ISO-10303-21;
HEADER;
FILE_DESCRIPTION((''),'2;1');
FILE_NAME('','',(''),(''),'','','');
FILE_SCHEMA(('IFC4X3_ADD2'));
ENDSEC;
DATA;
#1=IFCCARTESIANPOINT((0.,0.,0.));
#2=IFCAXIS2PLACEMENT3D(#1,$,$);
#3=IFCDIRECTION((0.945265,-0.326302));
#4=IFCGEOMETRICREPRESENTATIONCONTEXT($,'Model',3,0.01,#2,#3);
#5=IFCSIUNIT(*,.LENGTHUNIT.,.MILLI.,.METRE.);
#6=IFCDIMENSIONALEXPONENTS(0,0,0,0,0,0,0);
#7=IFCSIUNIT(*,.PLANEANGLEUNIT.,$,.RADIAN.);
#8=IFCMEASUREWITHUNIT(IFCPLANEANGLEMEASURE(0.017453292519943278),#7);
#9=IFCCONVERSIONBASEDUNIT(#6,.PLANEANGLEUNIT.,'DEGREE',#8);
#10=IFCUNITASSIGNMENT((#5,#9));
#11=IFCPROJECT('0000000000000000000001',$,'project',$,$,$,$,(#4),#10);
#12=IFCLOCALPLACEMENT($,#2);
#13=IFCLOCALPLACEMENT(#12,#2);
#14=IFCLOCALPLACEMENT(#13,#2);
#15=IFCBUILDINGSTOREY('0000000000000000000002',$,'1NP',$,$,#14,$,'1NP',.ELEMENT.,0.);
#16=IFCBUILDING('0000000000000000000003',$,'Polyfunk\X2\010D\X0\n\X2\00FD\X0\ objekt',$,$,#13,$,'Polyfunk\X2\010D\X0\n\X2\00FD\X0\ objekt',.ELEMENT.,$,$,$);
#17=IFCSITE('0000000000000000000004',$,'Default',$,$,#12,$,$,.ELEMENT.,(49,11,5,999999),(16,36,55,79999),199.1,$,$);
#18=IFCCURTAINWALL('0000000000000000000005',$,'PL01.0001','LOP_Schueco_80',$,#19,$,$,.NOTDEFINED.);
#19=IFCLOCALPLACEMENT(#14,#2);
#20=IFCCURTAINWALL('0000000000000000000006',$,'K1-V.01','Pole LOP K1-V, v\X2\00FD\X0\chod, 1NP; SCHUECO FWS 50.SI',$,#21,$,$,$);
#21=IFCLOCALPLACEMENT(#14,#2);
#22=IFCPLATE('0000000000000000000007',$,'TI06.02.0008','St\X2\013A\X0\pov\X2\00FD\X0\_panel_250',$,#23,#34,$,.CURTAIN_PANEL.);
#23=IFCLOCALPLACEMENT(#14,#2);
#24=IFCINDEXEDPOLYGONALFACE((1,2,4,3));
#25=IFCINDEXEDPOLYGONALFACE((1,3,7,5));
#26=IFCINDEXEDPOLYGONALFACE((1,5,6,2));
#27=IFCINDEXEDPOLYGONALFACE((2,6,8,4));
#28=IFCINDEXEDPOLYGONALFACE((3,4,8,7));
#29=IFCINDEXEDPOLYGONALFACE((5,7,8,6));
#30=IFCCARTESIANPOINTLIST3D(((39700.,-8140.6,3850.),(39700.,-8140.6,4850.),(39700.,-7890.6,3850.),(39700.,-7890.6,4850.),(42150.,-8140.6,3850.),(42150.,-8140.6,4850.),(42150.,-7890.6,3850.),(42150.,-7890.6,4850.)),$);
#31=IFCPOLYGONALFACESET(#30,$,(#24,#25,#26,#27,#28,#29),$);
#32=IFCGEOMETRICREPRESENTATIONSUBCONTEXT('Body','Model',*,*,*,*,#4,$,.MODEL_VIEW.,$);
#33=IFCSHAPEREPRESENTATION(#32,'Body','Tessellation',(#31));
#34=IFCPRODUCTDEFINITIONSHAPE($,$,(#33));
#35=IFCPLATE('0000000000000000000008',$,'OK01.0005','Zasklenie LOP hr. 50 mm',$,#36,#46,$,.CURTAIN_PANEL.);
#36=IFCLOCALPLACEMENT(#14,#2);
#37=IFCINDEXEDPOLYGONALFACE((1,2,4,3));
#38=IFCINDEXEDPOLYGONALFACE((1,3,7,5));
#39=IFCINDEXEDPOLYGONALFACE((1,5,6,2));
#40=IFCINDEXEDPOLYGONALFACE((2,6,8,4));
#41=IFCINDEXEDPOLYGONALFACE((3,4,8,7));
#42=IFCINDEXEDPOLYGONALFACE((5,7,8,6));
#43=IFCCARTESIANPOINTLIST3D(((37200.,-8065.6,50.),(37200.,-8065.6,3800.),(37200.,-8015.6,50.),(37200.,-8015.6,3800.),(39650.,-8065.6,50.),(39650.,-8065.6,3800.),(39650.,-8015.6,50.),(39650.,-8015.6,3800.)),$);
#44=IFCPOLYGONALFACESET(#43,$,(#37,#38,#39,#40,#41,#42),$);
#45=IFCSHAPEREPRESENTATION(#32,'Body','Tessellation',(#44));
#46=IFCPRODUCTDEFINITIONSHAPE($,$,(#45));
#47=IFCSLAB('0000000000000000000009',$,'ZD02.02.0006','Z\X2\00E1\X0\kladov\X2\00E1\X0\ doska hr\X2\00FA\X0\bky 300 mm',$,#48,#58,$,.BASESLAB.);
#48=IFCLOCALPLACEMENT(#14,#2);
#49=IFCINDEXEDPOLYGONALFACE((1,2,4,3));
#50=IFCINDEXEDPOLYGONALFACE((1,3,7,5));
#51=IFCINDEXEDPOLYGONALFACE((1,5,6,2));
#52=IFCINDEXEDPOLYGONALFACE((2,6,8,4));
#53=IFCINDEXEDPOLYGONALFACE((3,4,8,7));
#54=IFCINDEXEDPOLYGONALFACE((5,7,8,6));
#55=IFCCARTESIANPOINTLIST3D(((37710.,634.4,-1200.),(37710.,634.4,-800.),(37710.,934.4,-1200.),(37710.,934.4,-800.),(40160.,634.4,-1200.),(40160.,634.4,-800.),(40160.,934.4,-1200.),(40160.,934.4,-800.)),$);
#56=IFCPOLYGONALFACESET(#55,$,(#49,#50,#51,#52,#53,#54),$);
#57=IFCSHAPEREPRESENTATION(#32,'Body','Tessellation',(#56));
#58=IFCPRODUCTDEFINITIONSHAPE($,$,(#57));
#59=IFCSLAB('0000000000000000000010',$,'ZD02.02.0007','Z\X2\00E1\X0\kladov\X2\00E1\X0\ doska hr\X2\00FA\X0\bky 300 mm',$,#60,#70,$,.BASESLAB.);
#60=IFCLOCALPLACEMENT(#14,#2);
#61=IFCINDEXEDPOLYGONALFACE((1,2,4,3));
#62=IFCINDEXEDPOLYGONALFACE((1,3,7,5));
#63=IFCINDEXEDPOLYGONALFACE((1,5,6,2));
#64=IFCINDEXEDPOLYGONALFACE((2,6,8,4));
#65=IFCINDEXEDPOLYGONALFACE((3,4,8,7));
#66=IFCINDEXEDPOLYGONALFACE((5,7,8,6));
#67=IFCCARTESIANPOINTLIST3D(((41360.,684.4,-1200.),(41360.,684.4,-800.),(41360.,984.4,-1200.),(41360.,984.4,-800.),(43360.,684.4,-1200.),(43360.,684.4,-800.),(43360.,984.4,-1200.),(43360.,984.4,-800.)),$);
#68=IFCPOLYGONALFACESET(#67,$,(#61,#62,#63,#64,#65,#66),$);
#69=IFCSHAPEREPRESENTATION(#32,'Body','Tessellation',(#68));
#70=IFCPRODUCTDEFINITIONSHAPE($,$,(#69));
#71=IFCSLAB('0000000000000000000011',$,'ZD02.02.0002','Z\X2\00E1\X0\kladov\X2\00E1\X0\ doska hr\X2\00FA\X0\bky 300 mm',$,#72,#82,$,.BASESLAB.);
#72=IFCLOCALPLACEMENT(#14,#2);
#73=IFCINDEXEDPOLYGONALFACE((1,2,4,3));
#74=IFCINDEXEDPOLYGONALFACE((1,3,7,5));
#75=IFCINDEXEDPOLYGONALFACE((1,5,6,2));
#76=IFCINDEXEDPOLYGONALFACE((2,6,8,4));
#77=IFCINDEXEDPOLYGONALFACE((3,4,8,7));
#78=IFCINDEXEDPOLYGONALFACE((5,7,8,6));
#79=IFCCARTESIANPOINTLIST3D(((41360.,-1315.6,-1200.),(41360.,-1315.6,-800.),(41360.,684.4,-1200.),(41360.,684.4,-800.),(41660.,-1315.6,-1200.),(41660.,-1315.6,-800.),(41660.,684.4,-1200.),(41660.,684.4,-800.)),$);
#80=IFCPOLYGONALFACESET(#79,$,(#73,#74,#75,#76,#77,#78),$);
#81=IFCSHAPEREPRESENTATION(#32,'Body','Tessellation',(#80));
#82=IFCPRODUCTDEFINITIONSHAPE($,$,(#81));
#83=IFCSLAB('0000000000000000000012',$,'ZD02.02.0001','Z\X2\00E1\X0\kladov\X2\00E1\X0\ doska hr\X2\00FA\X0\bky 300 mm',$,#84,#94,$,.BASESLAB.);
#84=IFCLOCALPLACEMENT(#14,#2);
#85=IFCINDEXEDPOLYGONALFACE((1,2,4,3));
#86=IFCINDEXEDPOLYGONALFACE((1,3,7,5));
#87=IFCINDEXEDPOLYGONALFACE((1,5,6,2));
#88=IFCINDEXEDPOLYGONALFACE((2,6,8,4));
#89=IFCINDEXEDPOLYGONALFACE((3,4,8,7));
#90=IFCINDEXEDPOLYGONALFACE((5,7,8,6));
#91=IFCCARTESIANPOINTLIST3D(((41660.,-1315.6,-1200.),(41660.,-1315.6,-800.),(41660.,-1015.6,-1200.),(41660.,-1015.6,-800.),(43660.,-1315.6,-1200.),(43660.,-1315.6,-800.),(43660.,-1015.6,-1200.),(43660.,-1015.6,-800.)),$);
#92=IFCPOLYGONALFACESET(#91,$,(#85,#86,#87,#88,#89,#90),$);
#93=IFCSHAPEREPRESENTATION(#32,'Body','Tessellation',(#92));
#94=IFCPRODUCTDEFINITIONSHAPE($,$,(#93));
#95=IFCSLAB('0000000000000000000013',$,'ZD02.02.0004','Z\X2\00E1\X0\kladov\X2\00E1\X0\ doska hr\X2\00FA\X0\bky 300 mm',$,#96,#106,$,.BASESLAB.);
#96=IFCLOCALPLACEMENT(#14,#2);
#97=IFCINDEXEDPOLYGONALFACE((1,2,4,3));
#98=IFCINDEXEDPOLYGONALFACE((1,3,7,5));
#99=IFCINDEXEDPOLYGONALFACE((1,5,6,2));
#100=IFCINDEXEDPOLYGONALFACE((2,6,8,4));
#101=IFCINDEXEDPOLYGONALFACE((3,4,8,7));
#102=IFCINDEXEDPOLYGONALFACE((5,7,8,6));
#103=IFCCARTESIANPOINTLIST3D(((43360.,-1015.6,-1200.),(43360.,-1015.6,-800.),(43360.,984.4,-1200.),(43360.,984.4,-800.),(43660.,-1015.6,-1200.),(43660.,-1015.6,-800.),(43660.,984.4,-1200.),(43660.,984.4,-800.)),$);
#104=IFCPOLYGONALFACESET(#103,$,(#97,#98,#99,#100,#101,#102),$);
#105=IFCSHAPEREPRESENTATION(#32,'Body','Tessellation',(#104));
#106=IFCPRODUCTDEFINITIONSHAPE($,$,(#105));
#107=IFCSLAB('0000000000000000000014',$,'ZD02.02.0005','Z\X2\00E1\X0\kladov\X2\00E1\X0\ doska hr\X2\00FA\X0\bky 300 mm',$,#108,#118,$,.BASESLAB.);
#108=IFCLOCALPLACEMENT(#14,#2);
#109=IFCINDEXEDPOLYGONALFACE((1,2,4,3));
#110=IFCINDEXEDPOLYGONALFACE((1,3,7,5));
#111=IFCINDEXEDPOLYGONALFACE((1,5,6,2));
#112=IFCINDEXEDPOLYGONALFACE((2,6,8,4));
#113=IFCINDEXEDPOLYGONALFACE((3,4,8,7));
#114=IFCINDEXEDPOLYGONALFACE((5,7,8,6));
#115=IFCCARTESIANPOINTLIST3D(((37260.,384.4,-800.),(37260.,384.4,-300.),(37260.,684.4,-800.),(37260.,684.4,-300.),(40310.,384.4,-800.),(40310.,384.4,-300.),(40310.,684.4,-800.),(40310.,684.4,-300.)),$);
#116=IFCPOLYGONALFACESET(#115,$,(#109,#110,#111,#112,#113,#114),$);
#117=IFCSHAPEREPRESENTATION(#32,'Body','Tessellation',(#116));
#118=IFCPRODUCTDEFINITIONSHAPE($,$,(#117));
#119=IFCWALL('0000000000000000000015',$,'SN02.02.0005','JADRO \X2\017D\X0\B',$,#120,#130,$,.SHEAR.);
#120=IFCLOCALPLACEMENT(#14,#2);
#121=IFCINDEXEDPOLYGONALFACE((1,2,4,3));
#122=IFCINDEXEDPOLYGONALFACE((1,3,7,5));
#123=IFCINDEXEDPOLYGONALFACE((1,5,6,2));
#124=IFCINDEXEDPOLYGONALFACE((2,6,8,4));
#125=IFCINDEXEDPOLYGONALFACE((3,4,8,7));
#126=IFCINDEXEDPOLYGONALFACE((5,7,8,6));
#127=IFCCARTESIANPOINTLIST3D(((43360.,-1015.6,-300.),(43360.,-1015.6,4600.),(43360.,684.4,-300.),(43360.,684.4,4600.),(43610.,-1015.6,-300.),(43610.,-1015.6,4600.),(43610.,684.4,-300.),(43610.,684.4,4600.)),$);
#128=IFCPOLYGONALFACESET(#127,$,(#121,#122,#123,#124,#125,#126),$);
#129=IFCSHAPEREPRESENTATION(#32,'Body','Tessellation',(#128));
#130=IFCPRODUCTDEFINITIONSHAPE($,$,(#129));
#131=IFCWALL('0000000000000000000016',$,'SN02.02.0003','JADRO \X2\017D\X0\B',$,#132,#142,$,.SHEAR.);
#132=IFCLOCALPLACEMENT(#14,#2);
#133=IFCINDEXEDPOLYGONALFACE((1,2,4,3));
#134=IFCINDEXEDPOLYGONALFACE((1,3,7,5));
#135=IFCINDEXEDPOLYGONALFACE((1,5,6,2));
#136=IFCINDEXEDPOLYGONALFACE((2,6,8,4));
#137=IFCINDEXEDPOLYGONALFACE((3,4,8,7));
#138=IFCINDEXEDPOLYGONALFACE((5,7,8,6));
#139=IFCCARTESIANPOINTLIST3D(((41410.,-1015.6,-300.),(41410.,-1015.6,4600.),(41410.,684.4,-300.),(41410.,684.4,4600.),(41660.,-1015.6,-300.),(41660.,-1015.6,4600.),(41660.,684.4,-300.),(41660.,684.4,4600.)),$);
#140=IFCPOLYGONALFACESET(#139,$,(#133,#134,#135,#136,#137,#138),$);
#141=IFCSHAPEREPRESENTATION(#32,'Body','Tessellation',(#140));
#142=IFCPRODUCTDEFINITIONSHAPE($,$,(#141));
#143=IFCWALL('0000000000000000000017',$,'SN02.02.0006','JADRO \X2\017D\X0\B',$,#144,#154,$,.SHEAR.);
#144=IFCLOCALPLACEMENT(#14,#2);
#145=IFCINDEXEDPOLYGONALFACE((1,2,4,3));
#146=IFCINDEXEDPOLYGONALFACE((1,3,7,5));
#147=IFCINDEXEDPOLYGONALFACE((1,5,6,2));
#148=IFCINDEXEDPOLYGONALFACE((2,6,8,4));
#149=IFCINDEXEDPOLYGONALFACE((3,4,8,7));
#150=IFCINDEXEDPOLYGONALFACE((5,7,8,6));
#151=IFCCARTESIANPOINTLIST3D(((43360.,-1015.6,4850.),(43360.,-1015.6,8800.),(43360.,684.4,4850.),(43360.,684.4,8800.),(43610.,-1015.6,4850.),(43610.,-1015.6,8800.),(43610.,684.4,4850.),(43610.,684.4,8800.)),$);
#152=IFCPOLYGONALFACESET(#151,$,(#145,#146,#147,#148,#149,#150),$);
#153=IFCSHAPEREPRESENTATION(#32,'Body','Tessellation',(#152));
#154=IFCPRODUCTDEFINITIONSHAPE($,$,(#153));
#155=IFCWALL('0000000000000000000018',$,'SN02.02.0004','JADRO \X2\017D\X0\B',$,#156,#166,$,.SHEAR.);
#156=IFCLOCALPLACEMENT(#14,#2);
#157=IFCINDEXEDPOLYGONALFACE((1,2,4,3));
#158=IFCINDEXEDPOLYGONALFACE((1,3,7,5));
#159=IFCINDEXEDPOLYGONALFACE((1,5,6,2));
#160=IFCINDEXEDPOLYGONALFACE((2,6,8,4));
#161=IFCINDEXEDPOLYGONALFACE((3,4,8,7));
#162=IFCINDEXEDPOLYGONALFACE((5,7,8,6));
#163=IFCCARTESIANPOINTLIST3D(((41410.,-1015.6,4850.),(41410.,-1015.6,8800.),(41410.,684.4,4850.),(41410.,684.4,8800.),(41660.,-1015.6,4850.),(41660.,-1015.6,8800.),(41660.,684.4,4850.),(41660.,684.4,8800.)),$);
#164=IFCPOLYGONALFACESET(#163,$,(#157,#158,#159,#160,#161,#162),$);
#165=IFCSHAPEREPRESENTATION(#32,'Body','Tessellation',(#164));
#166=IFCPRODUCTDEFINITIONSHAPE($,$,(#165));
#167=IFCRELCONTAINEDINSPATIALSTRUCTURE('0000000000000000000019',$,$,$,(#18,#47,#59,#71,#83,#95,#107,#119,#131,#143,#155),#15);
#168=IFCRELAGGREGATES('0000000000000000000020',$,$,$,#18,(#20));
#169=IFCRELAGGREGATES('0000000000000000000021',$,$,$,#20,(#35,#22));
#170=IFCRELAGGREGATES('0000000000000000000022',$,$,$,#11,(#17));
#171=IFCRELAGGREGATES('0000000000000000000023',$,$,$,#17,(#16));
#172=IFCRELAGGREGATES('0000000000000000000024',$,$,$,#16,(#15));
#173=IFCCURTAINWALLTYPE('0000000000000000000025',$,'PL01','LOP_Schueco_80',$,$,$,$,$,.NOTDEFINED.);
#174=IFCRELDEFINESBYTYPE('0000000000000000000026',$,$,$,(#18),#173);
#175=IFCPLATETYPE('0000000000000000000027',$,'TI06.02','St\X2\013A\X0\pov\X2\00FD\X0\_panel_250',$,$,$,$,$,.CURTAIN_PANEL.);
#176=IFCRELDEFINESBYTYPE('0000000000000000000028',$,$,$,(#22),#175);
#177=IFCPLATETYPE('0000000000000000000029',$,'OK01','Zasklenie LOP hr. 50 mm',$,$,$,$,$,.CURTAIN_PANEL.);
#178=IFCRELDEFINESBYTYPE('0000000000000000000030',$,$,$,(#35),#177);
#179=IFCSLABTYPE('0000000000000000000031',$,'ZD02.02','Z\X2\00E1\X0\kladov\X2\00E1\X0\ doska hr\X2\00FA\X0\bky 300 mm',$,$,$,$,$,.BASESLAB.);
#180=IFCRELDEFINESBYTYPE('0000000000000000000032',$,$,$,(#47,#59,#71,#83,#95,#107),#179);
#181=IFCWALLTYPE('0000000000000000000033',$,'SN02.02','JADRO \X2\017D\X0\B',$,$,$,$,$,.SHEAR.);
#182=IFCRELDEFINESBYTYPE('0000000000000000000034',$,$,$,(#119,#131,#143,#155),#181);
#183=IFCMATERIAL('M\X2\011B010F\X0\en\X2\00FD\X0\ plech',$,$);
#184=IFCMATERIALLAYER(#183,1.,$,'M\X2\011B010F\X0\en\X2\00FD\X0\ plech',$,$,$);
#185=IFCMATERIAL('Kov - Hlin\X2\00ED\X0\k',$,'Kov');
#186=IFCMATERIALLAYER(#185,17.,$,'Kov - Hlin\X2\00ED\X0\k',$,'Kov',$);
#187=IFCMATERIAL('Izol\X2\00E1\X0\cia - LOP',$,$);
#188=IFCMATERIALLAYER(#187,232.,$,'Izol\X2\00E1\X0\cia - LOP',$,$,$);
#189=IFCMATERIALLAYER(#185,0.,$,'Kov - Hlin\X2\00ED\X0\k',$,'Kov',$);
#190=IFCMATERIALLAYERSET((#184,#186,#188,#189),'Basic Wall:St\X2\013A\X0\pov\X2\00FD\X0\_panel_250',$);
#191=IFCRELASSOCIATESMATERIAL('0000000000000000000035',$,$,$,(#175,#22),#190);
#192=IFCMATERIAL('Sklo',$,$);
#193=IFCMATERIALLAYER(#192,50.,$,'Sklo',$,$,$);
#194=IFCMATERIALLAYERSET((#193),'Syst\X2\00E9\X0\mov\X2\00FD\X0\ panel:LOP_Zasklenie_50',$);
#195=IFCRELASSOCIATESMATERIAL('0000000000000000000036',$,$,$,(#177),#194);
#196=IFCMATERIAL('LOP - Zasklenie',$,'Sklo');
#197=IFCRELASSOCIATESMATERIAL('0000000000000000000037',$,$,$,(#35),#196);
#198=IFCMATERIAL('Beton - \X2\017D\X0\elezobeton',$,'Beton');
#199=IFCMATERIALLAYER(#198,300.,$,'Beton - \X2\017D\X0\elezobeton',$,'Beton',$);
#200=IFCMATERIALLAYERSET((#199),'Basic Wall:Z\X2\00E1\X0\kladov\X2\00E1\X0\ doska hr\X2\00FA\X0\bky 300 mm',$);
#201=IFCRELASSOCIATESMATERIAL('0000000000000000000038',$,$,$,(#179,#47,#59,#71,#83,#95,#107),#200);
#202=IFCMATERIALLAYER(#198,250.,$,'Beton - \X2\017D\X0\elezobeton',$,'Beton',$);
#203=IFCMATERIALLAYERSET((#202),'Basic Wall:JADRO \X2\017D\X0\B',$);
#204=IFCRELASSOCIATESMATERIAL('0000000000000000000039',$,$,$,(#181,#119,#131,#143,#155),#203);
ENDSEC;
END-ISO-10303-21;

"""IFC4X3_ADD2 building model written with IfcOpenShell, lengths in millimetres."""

from ifc_helpers import new_model, entity, si_unit, converted_unit, direction, frame, frame_2d, origin, place, context, subcontext, project, spatial, polyline, rectangle, extrude, clip, bounded_halfspace, source, transform, mapped, material, layer, layer_set, layer_usage, type_object, type_shapes, element, aggregate, save


model = new_model("IFC4X3_ADD2")

# Units and contexts
model_context = context("Model", 3, precision=0.01, world=origin(), true_north=direction((0.945265, -0.326302)))
body_context = subcontext(model_context, "Body", "Model", "MODEL_VIEW")
ifc_project = project(units=[si_unit("LENGTHUNIT", "METRE", prefix="MILLI"), converted_unit("PLANEANGLEUNIT", "DEGREE", entity("IfcPlaneAngleMeasure", 0.017453292519943278), si_unit("PLANEANGLEUNIT", "RADIAN"), dimensions=[0, 0, 0, 0, 0, 0, 0])], contexts=[model_context])

# Site, building, storey
site_placement = place(None, origin())
site = spatial("IfcSite", under=ifc_project, at=site_placement, Name="Default", CompositionType="ELEMENT", RefLatitude=(49, 11, 5, 999999), RefLongitude=(16, 36, 55, 79999), RefElevation=199.1)
building_placement = place(site_placement, origin())
building = spatial("IfcBuilding", under=site, at=building_placement, Name="Polyfunkčný objekt", LongName="Polyfunkčný objekt", CompositionType="ELEMENT")
storey_placement = place(building_placement, origin())
storey = spatial("IfcBuildingStorey", under=building, at=storey_placement, Name="1NP", LongName="1NP", CompositionType="ELEMENT", Elevation=0.0)

# Curtain walls, plates
curtain_wall_type = type_object("IfcCurtainWallType", Name="PL01", Description="LOP_Schueco_80", PredefinedType="NOTDEFINED")
curtain_wall_1_placement = place(storey_placement, origin())
curtain_wall_1 = element("IfcCurtainWall", 1, at=curtain_wall_1_placement, inside=storey, type_object=curtain_wall_type, Name="PL01.0001", Description="LOP_Schueco_80", PredefinedType="NOTDEFINED")
curtain_wall_2 = element("IfcCurtainWall", 2, Name="K1-V.01", Description="Pole LOP K1-V, východ, 1NP; SCHUECO FWS 50.SI")
aggregate(curtain_wall_1, [curtain_wall_2])
ifc_material_1 = material(Name="Měďený plech")
ifc_layer_1 = layer(ifc_material_1, 1.0, Name="Měďený plech")
ifc_material_2 = material(Name="Kov - Hliník", Category="Kov")
ifc_layer_2 = layer(ifc_material_2, 17.0, Name="Kov - Hliník", Category="Kov")
ifc_material_3 = material(Name="Izolácia - LOP")
ifc_layer_3 = layer(ifc_material_3, 232.0, Name="Izolácia - LOP")
ifc_layer_4 = layer(ifc_material_2, 0.0, Name="Kov - Hliník", Category="Kov")
ifc_layer_set_1 = layer_set([ifc_layer_1, ifc_layer_2, ifc_layer_3, ifc_layer_4], Name="Basic Wall:Stĺpový_panel_250")
ifc_layer_usage = layer_usage(ifc_layer_set_1, "AXIS2", "POSITIVE", -125.0)
plate_type_1 = type_object("IfcPlateType", Name="TI06.02", Description="Stĺpový_panel_250", PredefinedType="CURTAIN_PANEL", material=ifc_layer_set_1)
plate_1_placement = place(storey_placement, frame((39700.0, -8015.6, 3850.0)))
plate_1 = element("IfcPlate", 3, at=plate_1_placement, type_object=plate_type_1, material=ifc_layer_usage, Name="TI06.02.0008", Description="Stĺpový_panel_250", PredefinedType="CURTAIN_PANEL", context=body_context, shape_type="SweptSolid", body=[
    extrude(rectangle(XDim=250.0, YDim=2450.0, at=frame_2d((0.0, 0.0), x_axis=(1.0, 0.0))), frame((1225.0, 0.0, 0.0), z_axis=(0.0, 0.0, 1.0), x_axis=(0.0, 1.0, 0.0)), (0.0, 0.0, 1.0), 1000.0),
])
ifc_material_4 = material(Name="LOP - Zasklenie", Category="Sklo")
ifc_material_5 = material(Name="Sklo")
ifc_layer_5 = layer(ifc_material_5, 50.0, Name="Sklo")
ifc_layer_set_2 = layer_set([ifc_layer_5], Name="Systémový panel:LOP_Zasklenie_50")
plate_type_2 = type_object("IfcPlateType", Name="OK01", Description="Zasklenie LOP hr. 50 mm", PredefinedType="CURTAIN_PANEL", material=ifc_layer_set_2)
shared_shape_1 = source(origin(), body_context, "Body", "SweptSolid", [
    extrude(rectangle(XDim=3750.0, YDim=2450.0, at=frame_2d((-331.2, 0.0), x_axis=(1.0, 0.0))), frame((0.0, -50.0, 2206.2), z_axis=(0.0, 1.0, 0.0), x_axis=(0.0, 0.0, 1.0)), (0.0, 0.0, 1.0), 50.0),
])
type_shapes(plate_type_2, [shared_shape_1])
plate_2_placement = place(curtain_wall_1_placement, frame((38425.0, -8015.6, 50.0)))
plate_2 = element("IfcPlate", 4, at=plate_2_placement, type_object=plate_type_2, material=ifc_material_4, Name="OK01.0005", Description="Zasklenie LOP hr. 50 mm", PredefinedType="CURTAIN_PANEL", context=body_context, shape_type="MappedRepresentation", body=[
    mapped(shared_shape_1, transform((0.0, 0.0, 0.0), scale=1.0)),
])
aggregate(curtain_wall_2, [plate_2, plate_1])

# Slabs
ifc_material_6 = material(Name="Beton - Železobeton", Category="Beton")
ifc_layer_6 = layer(ifc_material_6, 300.0, Name="Beton - Železobeton", Category="Beton")
ifc_layer_set_3 = layer_set([ifc_layer_6], Name="Basic Wall:Základová doska hrúbky 300 mm")
slab_type = type_object("IfcSlabType", Name="ZD02.02", Description="Základová doska hrúbky 300 mm", PredefinedType="BASESLAB", material=ifc_layer_set_3)
slab_1_placement = place(storey_placement, frame((40160.0, 784.4, -1200.0), z_axis=(0.0, 0.0, 1.0), x_axis=(-1.0, 0.0, 0.0)))
element("IfcSlab", 5, at=slab_1_placement, inside=storey, type_object=slab_type, material=ifc_layer_set_3, Name="ZD02.02.0006", Description="Základová doska hrúbky 300 mm", PredefinedType="BASESLAB", context=body_context, shape_type="SweptSolid", body=[
    extrude(rectangle(XDim=2450.0, YDim=300.0, at=frame_2d((1225.0, 0.0), x_axis=(-1.0, 0.0))), origin(), (0.0, 0.0, 1.0), 400.0),
])
slab_2_placement = place(storey_placement, frame((41360.0, 834.4, -1200.0)))
element("IfcSlab", 6, at=slab_2_placement, inside=storey, type_object=slab_type, material=ifc_layer_set_3, Name="ZD02.02.0007", Description="Základová doska hrúbky 300 mm", PredefinedType="BASESLAB", context=body_context, shape_type="SweptSolid", body=[
    extrude(rectangle(XDim=2000.0, YDim=300.0, at=frame_2d((1000.0, 0.0), x_axis=(-1.0, 0.0))), origin(), (0.0, 0.0, 1.0), 400.0),
])
slab_3_placement = place(storey_placement, frame((41510.0, -1315.6, -1200.0), z_axis=(0.0, 0.0, 1.0), x_axis=(0.0, 1.0, 0.0)))
element("IfcSlab", 7, at=slab_3_placement, inside=storey, type_object=slab_type, material=ifc_layer_set_3, Name="ZD02.02.0002", Description="Základová doska hrúbky 300 mm", PredefinedType="BASESLAB", context=body_context, shape_type="SweptSolid", body=[
    extrude(rectangle(XDim=2000.0, YDim=300.0, at=frame_2d((1000.0, 0.0), x_axis=(-1.0, 0.0))), origin(), (0.0, 0.0, 1.0), 400.0),
])
slab_4_placement = place(storey_placement, frame((43660.0, -1165.6, -1200.0), z_axis=(0.0, 0.0, 1.0), x_axis=(-1.0, 0.0, 0.0)))
element("IfcSlab", 8, at=slab_4_placement, inside=storey, type_object=slab_type, material=ifc_layer_set_3, Name="ZD02.02.0001", Description="Základová doska hrúbky 300 mm", PredefinedType="BASESLAB", context=body_context, shape_type="SweptSolid", body=[
    extrude(rectangle(XDim=2000.0, YDim=300.0, at=frame_2d((1000.0, 0.0), x_axis=(-1.0, 0.0))), origin(), (0.0, 0.0, 1.0), 400.0),
])
slab_5_placement = place(storey_placement, frame((43510.0, 984.4, -1200.0), z_axis=(0.0, 0.0, 1.0), x_axis=(0.0, -1.0, 0.0)))
element("IfcSlab", 9, at=slab_5_placement, inside=storey, type_object=slab_type, material=ifc_layer_set_3, Name="ZD02.02.0004", Description="Základová doska hrúbky 300 mm", PredefinedType="BASESLAB", context=body_context, shape_type="SweptSolid", body=[
    extrude(rectangle(XDim=2000.0, YDim=300.0, at=frame_2d((1000.0, 0.0), x_axis=(-1.0, 0.0))), origin(), (0.0, 0.0, 1.0), 400.0),
])
slab_6_placement = place(storey_placement, frame((40310.0, 534.4, -800.0), z_axis=(0.0, 0.0, 1.0), x_axis=(-1.0, 0.0, 0.0)))
element("IfcSlab", 10, at=slab_6_placement, inside=storey, type_object=slab_type, material=ifc_layer_set_3, Name="ZD02.02.0005", Description="Základová doska hrúbky 300 mm", PredefinedType="BASESLAB", context=body_context, shape_type="SweptSolid", body=[
    extrude(rectangle(XDim=3050.0, YDim=300.0, at=frame_2d((1525.0, 0.0), x_axis=(-1.0, 0.0))), origin(), (0.0, 0.0, 1.0), 500.0),
])

# Walls
ifc_layer_7 = layer(ifc_material_6, 250.0, Name="Beton - Železobeton", Category="Beton")
ifc_layer_set_4 = layer_set([ifc_layer_7], Name="Basic Wall:JADRO ŽB")
wall_type_1 = type_object("IfcWallType", Name="SN02.02", Description="JADRO ŽB", PredefinedType="SHEAR", material=ifc_layer_set_4)
wall_1_placement = place(storey_placement, frame((43485.0, 684.4, -300.0), z_axis=(0.0, 0.0, 1.0), x_axis=(0.0, -1.0, 0.0)))
element("IfcWall", 11, at=wall_1_placement, inside=storey, type_object=wall_type_1, material=ifc_layer_set_4, Name="SN02.02.0005", Description="JADRO ŽB", PredefinedType="SHEAR", context=body_context, shape_type="Clipping", body=[
    clip(clip(extrude(rectangle(XDim=1700.0, YDim=250.0, at=frame_2d((850.0, 0.0), x_axis=(-1.0, 0.0))), origin(), (0.0, 0.0, 1.0), 4900.0), bounded_halfspace(frame((0.0, -125.0, 4900.0), z_axis=(0.0, 0.0, -1.0), x_axis=(0.0, 1.0, 0.0)), True, frame((0.0, -125.0, 4900.0)), polyline([(0.0, 0.0), (1700.0, 0.0), (1700.0, 250.0), (0.0, 250.0), (0.0, 0.0)]))), bounded_halfspace(frame((1700.0, -125.0, 0.0), z_axis=(0.0, 0.0, 1.0), x_axis=(-1.0, 0.0, 0.0)), True, frame((1700.0, -125.0, 0.0)), polyline([(0.0, 0.0), (0.0, 250.0), (-1700.0, 250.0), (-1700.0, 0.0), (0.0, 0.0)]))),
])
wall_2_placement = place(storey_placement, frame((41535.0, 684.4, -300.0), z_axis=(0.0, 0.0, 1.0), x_axis=(0.0, -1.0, 0.0)))
element("IfcWall", 12, at=wall_2_placement, inside=storey, type_object=wall_type_1, material=ifc_layer_set_4, Name="SN02.02.0003", Description="JADRO ŽB", PredefinedType="SHEAR", context=body_context, shape_type="Clipping", body=[
    clip(clip(extrude(rectangle(XDim=1700.0, YDim=250.0, at=frame_2d((850.0, 0.0), x_axis=(-1.0, 0.0))), origin(), (0.0, 0.0, 1.0), 4900.0), bounded_halfspace(frame((0.0, -125.0, 4900.0), z_axis=(0.0, 0.0, -1.0), x_axis=(0.0, 1.0, 0.0)), True, frame((0.0, -125.0, 4900.0)), polyline([(0.0, 0.0), (1700.0, 0.0), (1700.0, 250.0), (0.0, 250.0), (0.0, 0.0)]))), bounded_halfspace(frame((1700.0, -125.0, 0.0), z_axis=(0.0, 0.0, 1.0), x_axis=(-1.0, 0.0, 0.0)), True, frame((1700.0, -125.0, 0.0)), polyline([(0.0, 0.0), (0.0, 250.0), (-1700.0, 250.0), (-1700.0, 0.0), (0.0, 0.0)]))),
])
wall_3_placement = place(storey_placement, frame((43485.0, 684.4, 4850.0), z_axis=(0.0, 0.0, 1.0), x_axis=(0.0, -1.0, 0.0)))
element("IfcWall", 13, at=wall_3_placement, inside=storey, type_object=wall_type_1, material=ifc_layer_set_4, Name="SN02.02.0006", Description="JADRO ŽB", PredefinedType="SHEAR", context=body_context, shape_type="Clipping", body=[
    clip(clip(extrude(rectangle(XDim=1700.0, YDim=250.0, at=frame_2d((850.0, 0.0), x_axis=(-1.0, 0.0))), origin(), (0.0, 0.0, 1.0), 3950.0), bounded_halfspace(frame((1700.0, -125.0, 0.0), z_axis=(0.0, 0.0, 1.0), x_axis=(0.0, -1.0, 0.0)), True, frame((1700.0, -125.0, 0.0)), polyline([(0.0, 0.0), (0.0, 250.0), (-1700.0, 250.0), (-1700.0, 0.0), (0.0, 0.0)]))), bounded_halfspace(frame((0.0, -125.0, 3950.0), z_axis=(0.0, 0.0, -1.0), x_axis=(0.0, 1.0, 0.0)), True, frame((0.0, -125.0, 3950.0)), polyline([(0.0, 0.0), (1700.0, 0.0), (1700.0, 250.0), (0.0, 250.0), (0.0, 0.0)]))),
])
wall_4_placement = place(storey_placement, frame((41535.0, 684.4, 4850.0), z_axis=(0.0, 0.0, 1.0), x_axis=(0.0, -1.0, 0.0)))
element("IfcWall", 14, at=wall_4_placement, inside=storey, type_object=wall_type_1, material=ifc_layer_set_4, Name="SN02.02.0004", Description="JADRO ŽB", PredefinedType="SHEAR", context=body_context, shape_type="Clipping", body=[
    clip(clip(extrude(rectangle(XDim=1700.0, YDim=250.0, at=frame_2d((850.0, 0.0), x_axis=(-1.0, 0.0))), origin(), (0.0, 0.0, 1.0), 3950.0), bounded_halfspace(frame((1700.0, -125.0, 0.0), z_axis=(0.0, 0.0, 1.0), x_axis=(0.0, -1.0, 0.0)), True, frame((1700.0, -125.0, 0.0)), polyline([(0.0, 0.0), (0.0, 250.0), (-1700.0, 250.0), (-1700.0, 0.0), (0.0, 0.0)]))), bounded_halfspace(frame((0.0, -125.0, 3950.0), z_axis=(0.0, 0.0, -1.0), x_axis=(0.0, 1.0, 0.0)), True, frame((0.0, -125.0, 3950.0)), polyline([(0.0, 0.0), (1700.0, 0.0), (1700.0, 250.0), (0.0, 250.0), (0.0, 0.0)]))),
])

save(model, "model.ifc")
